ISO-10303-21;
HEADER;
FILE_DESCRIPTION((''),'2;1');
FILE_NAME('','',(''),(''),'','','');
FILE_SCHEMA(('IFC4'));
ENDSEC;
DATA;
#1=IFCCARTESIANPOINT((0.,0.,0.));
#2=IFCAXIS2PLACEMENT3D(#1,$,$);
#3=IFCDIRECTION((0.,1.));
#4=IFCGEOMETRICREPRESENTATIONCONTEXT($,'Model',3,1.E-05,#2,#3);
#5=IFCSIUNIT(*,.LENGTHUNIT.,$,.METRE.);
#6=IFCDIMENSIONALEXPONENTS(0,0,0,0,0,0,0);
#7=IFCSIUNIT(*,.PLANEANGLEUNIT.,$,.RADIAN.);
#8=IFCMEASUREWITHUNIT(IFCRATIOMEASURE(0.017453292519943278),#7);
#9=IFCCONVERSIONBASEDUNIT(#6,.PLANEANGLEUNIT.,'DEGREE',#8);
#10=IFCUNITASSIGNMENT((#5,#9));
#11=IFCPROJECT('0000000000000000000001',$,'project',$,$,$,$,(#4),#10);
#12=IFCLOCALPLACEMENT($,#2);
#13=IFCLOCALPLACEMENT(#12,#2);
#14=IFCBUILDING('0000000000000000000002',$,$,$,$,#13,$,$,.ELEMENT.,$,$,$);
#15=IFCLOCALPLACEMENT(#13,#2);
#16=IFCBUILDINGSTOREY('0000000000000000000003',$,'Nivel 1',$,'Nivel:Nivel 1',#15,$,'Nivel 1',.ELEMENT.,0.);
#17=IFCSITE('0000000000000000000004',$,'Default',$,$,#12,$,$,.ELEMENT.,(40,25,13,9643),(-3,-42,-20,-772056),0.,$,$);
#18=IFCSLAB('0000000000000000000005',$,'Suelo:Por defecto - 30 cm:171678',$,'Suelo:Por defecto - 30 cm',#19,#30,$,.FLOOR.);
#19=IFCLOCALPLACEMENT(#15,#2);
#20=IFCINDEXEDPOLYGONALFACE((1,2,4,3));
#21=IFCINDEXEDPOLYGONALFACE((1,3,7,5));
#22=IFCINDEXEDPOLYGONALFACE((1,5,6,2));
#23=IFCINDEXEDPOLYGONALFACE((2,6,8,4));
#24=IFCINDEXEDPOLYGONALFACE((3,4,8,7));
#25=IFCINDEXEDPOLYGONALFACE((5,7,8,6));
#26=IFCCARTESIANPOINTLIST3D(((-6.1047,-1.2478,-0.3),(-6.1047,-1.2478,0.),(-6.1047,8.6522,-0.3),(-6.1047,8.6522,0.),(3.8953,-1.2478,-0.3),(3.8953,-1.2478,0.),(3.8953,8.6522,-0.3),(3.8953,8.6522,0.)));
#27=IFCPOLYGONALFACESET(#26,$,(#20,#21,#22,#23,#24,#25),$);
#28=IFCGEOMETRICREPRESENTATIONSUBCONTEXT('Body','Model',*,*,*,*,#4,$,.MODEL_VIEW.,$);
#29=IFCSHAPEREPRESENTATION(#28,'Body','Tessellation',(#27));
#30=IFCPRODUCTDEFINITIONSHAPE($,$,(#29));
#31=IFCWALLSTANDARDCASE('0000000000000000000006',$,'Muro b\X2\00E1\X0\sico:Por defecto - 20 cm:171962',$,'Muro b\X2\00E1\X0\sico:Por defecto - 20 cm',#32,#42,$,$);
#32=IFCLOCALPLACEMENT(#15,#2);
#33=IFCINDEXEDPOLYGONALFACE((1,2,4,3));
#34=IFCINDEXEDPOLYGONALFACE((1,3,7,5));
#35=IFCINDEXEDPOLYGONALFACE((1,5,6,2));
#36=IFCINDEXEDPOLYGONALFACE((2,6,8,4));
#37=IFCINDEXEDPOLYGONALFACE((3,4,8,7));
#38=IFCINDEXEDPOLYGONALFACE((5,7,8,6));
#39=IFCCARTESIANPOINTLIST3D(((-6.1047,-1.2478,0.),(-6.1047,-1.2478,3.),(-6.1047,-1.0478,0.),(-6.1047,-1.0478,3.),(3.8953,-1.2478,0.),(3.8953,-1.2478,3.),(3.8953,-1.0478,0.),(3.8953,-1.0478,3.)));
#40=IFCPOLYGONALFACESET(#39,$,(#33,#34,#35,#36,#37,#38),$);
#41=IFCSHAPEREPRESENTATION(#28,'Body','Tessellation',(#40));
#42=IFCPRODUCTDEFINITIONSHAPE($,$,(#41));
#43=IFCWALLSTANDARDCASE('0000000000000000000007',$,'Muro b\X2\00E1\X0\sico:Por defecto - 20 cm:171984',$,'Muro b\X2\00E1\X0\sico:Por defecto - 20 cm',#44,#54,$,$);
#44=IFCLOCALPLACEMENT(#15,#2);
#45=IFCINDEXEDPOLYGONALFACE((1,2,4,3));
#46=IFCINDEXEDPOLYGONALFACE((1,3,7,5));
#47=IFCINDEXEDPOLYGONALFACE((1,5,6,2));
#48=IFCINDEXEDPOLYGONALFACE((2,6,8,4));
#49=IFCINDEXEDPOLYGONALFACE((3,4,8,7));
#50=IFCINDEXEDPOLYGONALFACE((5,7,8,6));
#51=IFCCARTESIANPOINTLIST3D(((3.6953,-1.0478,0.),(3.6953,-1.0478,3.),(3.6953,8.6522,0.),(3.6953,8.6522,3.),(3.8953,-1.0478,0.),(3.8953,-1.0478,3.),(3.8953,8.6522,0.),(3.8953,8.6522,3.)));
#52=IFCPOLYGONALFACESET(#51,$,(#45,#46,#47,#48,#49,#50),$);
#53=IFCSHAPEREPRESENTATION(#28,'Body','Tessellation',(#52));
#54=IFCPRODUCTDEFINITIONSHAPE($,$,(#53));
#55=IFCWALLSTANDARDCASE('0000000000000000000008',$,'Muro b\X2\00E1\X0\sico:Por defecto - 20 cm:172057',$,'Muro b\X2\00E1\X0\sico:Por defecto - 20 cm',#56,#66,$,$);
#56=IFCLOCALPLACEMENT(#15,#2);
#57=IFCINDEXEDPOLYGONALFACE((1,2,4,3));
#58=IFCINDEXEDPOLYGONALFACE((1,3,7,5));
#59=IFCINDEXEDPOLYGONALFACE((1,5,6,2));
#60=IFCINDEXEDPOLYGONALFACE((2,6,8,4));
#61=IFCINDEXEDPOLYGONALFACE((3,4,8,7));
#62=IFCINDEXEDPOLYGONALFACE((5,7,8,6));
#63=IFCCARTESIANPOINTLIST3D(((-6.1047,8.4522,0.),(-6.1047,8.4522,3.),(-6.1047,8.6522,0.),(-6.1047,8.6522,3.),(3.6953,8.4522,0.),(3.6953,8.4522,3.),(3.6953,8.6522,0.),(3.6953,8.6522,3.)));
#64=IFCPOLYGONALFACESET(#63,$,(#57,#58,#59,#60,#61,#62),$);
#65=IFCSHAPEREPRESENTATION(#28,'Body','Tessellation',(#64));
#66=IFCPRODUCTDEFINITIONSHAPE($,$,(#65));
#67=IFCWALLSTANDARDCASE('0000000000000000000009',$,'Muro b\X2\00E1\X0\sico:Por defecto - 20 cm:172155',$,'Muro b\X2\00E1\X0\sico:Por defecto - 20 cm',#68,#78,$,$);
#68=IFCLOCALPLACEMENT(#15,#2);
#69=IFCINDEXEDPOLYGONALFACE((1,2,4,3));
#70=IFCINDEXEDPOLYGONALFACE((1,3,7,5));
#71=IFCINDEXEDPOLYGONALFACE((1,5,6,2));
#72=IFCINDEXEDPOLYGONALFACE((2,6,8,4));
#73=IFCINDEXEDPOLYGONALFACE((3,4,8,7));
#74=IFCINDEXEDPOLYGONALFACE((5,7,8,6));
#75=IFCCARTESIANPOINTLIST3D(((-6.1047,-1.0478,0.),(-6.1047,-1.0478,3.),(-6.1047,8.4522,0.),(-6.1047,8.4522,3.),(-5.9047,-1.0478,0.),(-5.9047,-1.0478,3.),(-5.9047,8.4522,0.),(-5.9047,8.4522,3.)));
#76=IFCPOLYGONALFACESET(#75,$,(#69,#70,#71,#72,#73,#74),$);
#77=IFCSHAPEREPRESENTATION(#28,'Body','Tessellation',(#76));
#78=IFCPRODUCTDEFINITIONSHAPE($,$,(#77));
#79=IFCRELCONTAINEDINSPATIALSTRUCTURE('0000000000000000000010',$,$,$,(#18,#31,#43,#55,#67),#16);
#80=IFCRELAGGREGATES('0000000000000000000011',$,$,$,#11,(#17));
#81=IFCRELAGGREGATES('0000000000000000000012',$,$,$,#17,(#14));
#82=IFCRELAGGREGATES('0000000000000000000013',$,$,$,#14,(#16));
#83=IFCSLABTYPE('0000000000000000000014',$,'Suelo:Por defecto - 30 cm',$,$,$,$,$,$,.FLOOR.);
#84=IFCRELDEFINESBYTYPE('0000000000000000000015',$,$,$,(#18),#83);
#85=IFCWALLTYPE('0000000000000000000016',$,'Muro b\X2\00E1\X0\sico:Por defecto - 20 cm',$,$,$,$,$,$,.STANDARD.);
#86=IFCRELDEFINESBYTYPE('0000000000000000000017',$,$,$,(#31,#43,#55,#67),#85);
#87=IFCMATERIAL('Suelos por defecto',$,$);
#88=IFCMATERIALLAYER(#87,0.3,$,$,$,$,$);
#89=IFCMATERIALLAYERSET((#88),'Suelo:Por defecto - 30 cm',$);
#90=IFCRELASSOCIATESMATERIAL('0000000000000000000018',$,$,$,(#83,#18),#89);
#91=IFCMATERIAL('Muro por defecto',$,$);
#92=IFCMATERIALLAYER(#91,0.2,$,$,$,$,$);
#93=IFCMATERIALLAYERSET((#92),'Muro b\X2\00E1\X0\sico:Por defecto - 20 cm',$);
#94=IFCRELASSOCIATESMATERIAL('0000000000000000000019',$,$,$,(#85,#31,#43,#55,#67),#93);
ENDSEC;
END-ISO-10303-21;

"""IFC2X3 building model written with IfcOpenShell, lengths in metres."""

from ifc_helpers import new_model, entity, si_unit, converted_unit, direction, frame, frame_2d, origin, origin_2d_with_axis, place, context, subcontext, project, spatial, rectangle, extrude, material, layer, layer_set, layer_usage, type_object, element, save


model = new_model("IFC2X3")

# Units and contexts
model_context = context("Model", 3, precision=1e-05, world=origin(), true_north=direction((0.0, 1.0)))
body_context = subcontext(model_context, "Body", "Model", "MODEL_VIEW")
ifc_project = project(units=[si_unit("LENGTHUNIT", "METRE"), converted_unit("PLANEANGLEUNIT", "DEGREE", entity("IfcRatioMeasure", 0.017453292519943278), si_unit("PLANEANGLEUNIT", "RADIAN"), dimensions=[0, 0, 0, 0, 0, 0, 0])], contexts=[model_context])

# Site, building, storey
site_placement = place(None, origin())
site = spatial("IfcSite", under=ifc_project, at=site_placement, Name="Default", CompositionType="ELEMENT", RefLatitude=(40, 25, 13, 9643), RefLongitude=(-3, -42, -20, -772056), RefElevation=0.0)
building_placement = place(site_placement, origin())
building = spatial("IfcBuilding", under=site, at=building_placement, CompositionType="ELEMENT")
storey_placement = place(building_placement, origin())
storey = spatial("IfcBuildingStorey", under=building, at=storey_placement, Name="Nivel 1", ObjectType="Nivel:Nivel 1", LongName="Nivel 1", CompositionType="ELEMENT", Elevation=0.0)

# Slab
ifc_material_1 = material(Name="Suelos por defecto")
ifc_layer_1 = layer(ifc_material_1, 0.3)
ifc_layer_set_1 = layer_set([ifc_layer_1], Name="Suelo:Por defecto - 30 cm")
ifc_layer_usage_1 = layer_usage(ifc_layer_set_1, "AXIS3", "POSITIVE", 0.0)
slab_type = type_object("IfcSlabType", Name="Suelo:Por defecto - 30 cm", PredefinedType="FLOOR", material=ifc_layer_set_1)
slab_placement = place(storey_placement, origin())
element("IfcSlab", 1, at=slab_placement, inside=storey, type_object=slab_type, material=ifc_layer_usage_1, Name="Suelo:Por defecto - 30 cm:171678", ObjectType="Suelo:Por defecto - 30 cm", PredefinedType="FLOOR", context=body_context, shape_type="SweptSolid", body=[
    extrude(rectangle(XDim=9.9, YDim=10.0, at=origin_2d_with_axis()), frame((-1.1047, 3.7022, 0.0), z_axis=(0.0, 0.0, -1.0), x_axis=(0.0, 1.0, 0.0)), (0.0, 0.0, 1.0), 0.3),
])

# Walls
ifc_material_2 = material(Name="Muro por defecto")
ifc_layer_2 = layer(ifc_material_2, 0.2)
ifc_layer_set_2 = layer_set([ifc_layer_2], Name="Muro básico:Por defecto - 20 cm")
ifc_layer_usage_2 = layer_usage(ifc_layer_set_2, "AXIS2", "NEGATIVE", 0.1)
wall_type = type_object("IfcWallType", Name="Muro básico:Por defecto - 20 cm", PredefinedType="STANDARD", material=ifc_layer_set_2)
wall_1_placement = place(storey_placement, frame((-6.1047, -1.1478, 0.0)))
element("IfcWallStandardCase", 2, at=wall_1_placement, inside=storey, type_object=wall_type, material=ifc_layer_usage_2, Name="Muro básico:Por defecto - 20 cm:171962", ObjectType="Muro básico:Por defecto - 20 cm", context=body_context, shape_type="SweptSolid", body=[
    extrude(rectangle(XDim=10.0, YDim=0.2, at=frame_2d((5.0, 0.0), x_axis=(-1.0, 0.0))), origin(), (0.0, 0.0, 1.0), 3.0),
])
ifc_layer_usage_3 = layer_usage(ifc_layer_set_2, "AXIS2", "NEGATIVE", 0.1)
wall_2_placement = place(storey_placement, frame((3.7953, -1.0478, 0.0), z_axis=(0.0, 0.0, 1.0), x_axis=(0.0, 1.0, 0.0)))
element("IfcWallStandardCase", 3, at=wall_2_placement, inside=storey, type_object=wall_type, material=ifc_layer_usage_3, Name="Muro básico:Por defecto - 20 cm:171984", ObjectType="Muro básico:Por defecto - 20 cm", context=body_context, shape_type="SweptSolid", body=[
    extrude(rectangle(XDim=9.7, YDim=0.2, at=frame_2d((4.85, 0.0), x_axis=(-1.0, 0.0))), origin(), (0.0, 0.0, 1.0), 3.0),
])
ifc_layer_usage_4 = layer_usage(ifc_layer_set_2, "AXIS2", "NEGATIVE", 0.1)
wall_3_placement = place(storey_placement, frame((3.6953, 8.5522, 0.0), z_axis=(0.0, 0.0, 1.0), x_axis=(-1.0, 0.0, 0.0)))
element("IfcWallStandardCase", 4, at=wall_3_placement, inside=storey, type_object=wall_type, material=ifc_layer_usage_4, Name="Muro básico:Por defecto - 20 cm:172057", ObjectType="Muro básico:Por defecto - 20 cm", context=body_context, shape_type="SweptSolid", body=[
    extrude(rectangle(XDim=9.8, YDim=0.2, at=frame_2d((4.9, 0.0), x_axis=(-1.0, 0.0))), origin(), (0.0, 0.0, 1.0), 3.0),
])
ifc_layer_usage_5 = layer_usage(ifc_layer_set_2, "AXIS2", "NEGATIVE", 0.1)
wall_4_placement = place(storey_placement, frame((-6.0047, 8.4522, 0.0), z_axis=(0.0, 0.0, 1.0), x_axis=(0.0, -1.0, 0.0)))
element("IfcWallStandardCase", 5, at=wall_4_placement, inside=storey, type_object=wall_type, material=ifc_layer_usage_5, Name="Muro básico:Por defecto - 20 cm:172155", ObjectType="Muro básico:Por defecto - 20 cm", context=body_context, shape_type="SweptSolid", body=[
    extrude(rectangle(XDim=9.5, YDim=0.2, at=frame_2d((4.75, 0.0), x_axis=(-1.0, 0.0))), origin(), (0.0, 0.0, 1.0), 3.0),
])

save(model, "model.ifc")
